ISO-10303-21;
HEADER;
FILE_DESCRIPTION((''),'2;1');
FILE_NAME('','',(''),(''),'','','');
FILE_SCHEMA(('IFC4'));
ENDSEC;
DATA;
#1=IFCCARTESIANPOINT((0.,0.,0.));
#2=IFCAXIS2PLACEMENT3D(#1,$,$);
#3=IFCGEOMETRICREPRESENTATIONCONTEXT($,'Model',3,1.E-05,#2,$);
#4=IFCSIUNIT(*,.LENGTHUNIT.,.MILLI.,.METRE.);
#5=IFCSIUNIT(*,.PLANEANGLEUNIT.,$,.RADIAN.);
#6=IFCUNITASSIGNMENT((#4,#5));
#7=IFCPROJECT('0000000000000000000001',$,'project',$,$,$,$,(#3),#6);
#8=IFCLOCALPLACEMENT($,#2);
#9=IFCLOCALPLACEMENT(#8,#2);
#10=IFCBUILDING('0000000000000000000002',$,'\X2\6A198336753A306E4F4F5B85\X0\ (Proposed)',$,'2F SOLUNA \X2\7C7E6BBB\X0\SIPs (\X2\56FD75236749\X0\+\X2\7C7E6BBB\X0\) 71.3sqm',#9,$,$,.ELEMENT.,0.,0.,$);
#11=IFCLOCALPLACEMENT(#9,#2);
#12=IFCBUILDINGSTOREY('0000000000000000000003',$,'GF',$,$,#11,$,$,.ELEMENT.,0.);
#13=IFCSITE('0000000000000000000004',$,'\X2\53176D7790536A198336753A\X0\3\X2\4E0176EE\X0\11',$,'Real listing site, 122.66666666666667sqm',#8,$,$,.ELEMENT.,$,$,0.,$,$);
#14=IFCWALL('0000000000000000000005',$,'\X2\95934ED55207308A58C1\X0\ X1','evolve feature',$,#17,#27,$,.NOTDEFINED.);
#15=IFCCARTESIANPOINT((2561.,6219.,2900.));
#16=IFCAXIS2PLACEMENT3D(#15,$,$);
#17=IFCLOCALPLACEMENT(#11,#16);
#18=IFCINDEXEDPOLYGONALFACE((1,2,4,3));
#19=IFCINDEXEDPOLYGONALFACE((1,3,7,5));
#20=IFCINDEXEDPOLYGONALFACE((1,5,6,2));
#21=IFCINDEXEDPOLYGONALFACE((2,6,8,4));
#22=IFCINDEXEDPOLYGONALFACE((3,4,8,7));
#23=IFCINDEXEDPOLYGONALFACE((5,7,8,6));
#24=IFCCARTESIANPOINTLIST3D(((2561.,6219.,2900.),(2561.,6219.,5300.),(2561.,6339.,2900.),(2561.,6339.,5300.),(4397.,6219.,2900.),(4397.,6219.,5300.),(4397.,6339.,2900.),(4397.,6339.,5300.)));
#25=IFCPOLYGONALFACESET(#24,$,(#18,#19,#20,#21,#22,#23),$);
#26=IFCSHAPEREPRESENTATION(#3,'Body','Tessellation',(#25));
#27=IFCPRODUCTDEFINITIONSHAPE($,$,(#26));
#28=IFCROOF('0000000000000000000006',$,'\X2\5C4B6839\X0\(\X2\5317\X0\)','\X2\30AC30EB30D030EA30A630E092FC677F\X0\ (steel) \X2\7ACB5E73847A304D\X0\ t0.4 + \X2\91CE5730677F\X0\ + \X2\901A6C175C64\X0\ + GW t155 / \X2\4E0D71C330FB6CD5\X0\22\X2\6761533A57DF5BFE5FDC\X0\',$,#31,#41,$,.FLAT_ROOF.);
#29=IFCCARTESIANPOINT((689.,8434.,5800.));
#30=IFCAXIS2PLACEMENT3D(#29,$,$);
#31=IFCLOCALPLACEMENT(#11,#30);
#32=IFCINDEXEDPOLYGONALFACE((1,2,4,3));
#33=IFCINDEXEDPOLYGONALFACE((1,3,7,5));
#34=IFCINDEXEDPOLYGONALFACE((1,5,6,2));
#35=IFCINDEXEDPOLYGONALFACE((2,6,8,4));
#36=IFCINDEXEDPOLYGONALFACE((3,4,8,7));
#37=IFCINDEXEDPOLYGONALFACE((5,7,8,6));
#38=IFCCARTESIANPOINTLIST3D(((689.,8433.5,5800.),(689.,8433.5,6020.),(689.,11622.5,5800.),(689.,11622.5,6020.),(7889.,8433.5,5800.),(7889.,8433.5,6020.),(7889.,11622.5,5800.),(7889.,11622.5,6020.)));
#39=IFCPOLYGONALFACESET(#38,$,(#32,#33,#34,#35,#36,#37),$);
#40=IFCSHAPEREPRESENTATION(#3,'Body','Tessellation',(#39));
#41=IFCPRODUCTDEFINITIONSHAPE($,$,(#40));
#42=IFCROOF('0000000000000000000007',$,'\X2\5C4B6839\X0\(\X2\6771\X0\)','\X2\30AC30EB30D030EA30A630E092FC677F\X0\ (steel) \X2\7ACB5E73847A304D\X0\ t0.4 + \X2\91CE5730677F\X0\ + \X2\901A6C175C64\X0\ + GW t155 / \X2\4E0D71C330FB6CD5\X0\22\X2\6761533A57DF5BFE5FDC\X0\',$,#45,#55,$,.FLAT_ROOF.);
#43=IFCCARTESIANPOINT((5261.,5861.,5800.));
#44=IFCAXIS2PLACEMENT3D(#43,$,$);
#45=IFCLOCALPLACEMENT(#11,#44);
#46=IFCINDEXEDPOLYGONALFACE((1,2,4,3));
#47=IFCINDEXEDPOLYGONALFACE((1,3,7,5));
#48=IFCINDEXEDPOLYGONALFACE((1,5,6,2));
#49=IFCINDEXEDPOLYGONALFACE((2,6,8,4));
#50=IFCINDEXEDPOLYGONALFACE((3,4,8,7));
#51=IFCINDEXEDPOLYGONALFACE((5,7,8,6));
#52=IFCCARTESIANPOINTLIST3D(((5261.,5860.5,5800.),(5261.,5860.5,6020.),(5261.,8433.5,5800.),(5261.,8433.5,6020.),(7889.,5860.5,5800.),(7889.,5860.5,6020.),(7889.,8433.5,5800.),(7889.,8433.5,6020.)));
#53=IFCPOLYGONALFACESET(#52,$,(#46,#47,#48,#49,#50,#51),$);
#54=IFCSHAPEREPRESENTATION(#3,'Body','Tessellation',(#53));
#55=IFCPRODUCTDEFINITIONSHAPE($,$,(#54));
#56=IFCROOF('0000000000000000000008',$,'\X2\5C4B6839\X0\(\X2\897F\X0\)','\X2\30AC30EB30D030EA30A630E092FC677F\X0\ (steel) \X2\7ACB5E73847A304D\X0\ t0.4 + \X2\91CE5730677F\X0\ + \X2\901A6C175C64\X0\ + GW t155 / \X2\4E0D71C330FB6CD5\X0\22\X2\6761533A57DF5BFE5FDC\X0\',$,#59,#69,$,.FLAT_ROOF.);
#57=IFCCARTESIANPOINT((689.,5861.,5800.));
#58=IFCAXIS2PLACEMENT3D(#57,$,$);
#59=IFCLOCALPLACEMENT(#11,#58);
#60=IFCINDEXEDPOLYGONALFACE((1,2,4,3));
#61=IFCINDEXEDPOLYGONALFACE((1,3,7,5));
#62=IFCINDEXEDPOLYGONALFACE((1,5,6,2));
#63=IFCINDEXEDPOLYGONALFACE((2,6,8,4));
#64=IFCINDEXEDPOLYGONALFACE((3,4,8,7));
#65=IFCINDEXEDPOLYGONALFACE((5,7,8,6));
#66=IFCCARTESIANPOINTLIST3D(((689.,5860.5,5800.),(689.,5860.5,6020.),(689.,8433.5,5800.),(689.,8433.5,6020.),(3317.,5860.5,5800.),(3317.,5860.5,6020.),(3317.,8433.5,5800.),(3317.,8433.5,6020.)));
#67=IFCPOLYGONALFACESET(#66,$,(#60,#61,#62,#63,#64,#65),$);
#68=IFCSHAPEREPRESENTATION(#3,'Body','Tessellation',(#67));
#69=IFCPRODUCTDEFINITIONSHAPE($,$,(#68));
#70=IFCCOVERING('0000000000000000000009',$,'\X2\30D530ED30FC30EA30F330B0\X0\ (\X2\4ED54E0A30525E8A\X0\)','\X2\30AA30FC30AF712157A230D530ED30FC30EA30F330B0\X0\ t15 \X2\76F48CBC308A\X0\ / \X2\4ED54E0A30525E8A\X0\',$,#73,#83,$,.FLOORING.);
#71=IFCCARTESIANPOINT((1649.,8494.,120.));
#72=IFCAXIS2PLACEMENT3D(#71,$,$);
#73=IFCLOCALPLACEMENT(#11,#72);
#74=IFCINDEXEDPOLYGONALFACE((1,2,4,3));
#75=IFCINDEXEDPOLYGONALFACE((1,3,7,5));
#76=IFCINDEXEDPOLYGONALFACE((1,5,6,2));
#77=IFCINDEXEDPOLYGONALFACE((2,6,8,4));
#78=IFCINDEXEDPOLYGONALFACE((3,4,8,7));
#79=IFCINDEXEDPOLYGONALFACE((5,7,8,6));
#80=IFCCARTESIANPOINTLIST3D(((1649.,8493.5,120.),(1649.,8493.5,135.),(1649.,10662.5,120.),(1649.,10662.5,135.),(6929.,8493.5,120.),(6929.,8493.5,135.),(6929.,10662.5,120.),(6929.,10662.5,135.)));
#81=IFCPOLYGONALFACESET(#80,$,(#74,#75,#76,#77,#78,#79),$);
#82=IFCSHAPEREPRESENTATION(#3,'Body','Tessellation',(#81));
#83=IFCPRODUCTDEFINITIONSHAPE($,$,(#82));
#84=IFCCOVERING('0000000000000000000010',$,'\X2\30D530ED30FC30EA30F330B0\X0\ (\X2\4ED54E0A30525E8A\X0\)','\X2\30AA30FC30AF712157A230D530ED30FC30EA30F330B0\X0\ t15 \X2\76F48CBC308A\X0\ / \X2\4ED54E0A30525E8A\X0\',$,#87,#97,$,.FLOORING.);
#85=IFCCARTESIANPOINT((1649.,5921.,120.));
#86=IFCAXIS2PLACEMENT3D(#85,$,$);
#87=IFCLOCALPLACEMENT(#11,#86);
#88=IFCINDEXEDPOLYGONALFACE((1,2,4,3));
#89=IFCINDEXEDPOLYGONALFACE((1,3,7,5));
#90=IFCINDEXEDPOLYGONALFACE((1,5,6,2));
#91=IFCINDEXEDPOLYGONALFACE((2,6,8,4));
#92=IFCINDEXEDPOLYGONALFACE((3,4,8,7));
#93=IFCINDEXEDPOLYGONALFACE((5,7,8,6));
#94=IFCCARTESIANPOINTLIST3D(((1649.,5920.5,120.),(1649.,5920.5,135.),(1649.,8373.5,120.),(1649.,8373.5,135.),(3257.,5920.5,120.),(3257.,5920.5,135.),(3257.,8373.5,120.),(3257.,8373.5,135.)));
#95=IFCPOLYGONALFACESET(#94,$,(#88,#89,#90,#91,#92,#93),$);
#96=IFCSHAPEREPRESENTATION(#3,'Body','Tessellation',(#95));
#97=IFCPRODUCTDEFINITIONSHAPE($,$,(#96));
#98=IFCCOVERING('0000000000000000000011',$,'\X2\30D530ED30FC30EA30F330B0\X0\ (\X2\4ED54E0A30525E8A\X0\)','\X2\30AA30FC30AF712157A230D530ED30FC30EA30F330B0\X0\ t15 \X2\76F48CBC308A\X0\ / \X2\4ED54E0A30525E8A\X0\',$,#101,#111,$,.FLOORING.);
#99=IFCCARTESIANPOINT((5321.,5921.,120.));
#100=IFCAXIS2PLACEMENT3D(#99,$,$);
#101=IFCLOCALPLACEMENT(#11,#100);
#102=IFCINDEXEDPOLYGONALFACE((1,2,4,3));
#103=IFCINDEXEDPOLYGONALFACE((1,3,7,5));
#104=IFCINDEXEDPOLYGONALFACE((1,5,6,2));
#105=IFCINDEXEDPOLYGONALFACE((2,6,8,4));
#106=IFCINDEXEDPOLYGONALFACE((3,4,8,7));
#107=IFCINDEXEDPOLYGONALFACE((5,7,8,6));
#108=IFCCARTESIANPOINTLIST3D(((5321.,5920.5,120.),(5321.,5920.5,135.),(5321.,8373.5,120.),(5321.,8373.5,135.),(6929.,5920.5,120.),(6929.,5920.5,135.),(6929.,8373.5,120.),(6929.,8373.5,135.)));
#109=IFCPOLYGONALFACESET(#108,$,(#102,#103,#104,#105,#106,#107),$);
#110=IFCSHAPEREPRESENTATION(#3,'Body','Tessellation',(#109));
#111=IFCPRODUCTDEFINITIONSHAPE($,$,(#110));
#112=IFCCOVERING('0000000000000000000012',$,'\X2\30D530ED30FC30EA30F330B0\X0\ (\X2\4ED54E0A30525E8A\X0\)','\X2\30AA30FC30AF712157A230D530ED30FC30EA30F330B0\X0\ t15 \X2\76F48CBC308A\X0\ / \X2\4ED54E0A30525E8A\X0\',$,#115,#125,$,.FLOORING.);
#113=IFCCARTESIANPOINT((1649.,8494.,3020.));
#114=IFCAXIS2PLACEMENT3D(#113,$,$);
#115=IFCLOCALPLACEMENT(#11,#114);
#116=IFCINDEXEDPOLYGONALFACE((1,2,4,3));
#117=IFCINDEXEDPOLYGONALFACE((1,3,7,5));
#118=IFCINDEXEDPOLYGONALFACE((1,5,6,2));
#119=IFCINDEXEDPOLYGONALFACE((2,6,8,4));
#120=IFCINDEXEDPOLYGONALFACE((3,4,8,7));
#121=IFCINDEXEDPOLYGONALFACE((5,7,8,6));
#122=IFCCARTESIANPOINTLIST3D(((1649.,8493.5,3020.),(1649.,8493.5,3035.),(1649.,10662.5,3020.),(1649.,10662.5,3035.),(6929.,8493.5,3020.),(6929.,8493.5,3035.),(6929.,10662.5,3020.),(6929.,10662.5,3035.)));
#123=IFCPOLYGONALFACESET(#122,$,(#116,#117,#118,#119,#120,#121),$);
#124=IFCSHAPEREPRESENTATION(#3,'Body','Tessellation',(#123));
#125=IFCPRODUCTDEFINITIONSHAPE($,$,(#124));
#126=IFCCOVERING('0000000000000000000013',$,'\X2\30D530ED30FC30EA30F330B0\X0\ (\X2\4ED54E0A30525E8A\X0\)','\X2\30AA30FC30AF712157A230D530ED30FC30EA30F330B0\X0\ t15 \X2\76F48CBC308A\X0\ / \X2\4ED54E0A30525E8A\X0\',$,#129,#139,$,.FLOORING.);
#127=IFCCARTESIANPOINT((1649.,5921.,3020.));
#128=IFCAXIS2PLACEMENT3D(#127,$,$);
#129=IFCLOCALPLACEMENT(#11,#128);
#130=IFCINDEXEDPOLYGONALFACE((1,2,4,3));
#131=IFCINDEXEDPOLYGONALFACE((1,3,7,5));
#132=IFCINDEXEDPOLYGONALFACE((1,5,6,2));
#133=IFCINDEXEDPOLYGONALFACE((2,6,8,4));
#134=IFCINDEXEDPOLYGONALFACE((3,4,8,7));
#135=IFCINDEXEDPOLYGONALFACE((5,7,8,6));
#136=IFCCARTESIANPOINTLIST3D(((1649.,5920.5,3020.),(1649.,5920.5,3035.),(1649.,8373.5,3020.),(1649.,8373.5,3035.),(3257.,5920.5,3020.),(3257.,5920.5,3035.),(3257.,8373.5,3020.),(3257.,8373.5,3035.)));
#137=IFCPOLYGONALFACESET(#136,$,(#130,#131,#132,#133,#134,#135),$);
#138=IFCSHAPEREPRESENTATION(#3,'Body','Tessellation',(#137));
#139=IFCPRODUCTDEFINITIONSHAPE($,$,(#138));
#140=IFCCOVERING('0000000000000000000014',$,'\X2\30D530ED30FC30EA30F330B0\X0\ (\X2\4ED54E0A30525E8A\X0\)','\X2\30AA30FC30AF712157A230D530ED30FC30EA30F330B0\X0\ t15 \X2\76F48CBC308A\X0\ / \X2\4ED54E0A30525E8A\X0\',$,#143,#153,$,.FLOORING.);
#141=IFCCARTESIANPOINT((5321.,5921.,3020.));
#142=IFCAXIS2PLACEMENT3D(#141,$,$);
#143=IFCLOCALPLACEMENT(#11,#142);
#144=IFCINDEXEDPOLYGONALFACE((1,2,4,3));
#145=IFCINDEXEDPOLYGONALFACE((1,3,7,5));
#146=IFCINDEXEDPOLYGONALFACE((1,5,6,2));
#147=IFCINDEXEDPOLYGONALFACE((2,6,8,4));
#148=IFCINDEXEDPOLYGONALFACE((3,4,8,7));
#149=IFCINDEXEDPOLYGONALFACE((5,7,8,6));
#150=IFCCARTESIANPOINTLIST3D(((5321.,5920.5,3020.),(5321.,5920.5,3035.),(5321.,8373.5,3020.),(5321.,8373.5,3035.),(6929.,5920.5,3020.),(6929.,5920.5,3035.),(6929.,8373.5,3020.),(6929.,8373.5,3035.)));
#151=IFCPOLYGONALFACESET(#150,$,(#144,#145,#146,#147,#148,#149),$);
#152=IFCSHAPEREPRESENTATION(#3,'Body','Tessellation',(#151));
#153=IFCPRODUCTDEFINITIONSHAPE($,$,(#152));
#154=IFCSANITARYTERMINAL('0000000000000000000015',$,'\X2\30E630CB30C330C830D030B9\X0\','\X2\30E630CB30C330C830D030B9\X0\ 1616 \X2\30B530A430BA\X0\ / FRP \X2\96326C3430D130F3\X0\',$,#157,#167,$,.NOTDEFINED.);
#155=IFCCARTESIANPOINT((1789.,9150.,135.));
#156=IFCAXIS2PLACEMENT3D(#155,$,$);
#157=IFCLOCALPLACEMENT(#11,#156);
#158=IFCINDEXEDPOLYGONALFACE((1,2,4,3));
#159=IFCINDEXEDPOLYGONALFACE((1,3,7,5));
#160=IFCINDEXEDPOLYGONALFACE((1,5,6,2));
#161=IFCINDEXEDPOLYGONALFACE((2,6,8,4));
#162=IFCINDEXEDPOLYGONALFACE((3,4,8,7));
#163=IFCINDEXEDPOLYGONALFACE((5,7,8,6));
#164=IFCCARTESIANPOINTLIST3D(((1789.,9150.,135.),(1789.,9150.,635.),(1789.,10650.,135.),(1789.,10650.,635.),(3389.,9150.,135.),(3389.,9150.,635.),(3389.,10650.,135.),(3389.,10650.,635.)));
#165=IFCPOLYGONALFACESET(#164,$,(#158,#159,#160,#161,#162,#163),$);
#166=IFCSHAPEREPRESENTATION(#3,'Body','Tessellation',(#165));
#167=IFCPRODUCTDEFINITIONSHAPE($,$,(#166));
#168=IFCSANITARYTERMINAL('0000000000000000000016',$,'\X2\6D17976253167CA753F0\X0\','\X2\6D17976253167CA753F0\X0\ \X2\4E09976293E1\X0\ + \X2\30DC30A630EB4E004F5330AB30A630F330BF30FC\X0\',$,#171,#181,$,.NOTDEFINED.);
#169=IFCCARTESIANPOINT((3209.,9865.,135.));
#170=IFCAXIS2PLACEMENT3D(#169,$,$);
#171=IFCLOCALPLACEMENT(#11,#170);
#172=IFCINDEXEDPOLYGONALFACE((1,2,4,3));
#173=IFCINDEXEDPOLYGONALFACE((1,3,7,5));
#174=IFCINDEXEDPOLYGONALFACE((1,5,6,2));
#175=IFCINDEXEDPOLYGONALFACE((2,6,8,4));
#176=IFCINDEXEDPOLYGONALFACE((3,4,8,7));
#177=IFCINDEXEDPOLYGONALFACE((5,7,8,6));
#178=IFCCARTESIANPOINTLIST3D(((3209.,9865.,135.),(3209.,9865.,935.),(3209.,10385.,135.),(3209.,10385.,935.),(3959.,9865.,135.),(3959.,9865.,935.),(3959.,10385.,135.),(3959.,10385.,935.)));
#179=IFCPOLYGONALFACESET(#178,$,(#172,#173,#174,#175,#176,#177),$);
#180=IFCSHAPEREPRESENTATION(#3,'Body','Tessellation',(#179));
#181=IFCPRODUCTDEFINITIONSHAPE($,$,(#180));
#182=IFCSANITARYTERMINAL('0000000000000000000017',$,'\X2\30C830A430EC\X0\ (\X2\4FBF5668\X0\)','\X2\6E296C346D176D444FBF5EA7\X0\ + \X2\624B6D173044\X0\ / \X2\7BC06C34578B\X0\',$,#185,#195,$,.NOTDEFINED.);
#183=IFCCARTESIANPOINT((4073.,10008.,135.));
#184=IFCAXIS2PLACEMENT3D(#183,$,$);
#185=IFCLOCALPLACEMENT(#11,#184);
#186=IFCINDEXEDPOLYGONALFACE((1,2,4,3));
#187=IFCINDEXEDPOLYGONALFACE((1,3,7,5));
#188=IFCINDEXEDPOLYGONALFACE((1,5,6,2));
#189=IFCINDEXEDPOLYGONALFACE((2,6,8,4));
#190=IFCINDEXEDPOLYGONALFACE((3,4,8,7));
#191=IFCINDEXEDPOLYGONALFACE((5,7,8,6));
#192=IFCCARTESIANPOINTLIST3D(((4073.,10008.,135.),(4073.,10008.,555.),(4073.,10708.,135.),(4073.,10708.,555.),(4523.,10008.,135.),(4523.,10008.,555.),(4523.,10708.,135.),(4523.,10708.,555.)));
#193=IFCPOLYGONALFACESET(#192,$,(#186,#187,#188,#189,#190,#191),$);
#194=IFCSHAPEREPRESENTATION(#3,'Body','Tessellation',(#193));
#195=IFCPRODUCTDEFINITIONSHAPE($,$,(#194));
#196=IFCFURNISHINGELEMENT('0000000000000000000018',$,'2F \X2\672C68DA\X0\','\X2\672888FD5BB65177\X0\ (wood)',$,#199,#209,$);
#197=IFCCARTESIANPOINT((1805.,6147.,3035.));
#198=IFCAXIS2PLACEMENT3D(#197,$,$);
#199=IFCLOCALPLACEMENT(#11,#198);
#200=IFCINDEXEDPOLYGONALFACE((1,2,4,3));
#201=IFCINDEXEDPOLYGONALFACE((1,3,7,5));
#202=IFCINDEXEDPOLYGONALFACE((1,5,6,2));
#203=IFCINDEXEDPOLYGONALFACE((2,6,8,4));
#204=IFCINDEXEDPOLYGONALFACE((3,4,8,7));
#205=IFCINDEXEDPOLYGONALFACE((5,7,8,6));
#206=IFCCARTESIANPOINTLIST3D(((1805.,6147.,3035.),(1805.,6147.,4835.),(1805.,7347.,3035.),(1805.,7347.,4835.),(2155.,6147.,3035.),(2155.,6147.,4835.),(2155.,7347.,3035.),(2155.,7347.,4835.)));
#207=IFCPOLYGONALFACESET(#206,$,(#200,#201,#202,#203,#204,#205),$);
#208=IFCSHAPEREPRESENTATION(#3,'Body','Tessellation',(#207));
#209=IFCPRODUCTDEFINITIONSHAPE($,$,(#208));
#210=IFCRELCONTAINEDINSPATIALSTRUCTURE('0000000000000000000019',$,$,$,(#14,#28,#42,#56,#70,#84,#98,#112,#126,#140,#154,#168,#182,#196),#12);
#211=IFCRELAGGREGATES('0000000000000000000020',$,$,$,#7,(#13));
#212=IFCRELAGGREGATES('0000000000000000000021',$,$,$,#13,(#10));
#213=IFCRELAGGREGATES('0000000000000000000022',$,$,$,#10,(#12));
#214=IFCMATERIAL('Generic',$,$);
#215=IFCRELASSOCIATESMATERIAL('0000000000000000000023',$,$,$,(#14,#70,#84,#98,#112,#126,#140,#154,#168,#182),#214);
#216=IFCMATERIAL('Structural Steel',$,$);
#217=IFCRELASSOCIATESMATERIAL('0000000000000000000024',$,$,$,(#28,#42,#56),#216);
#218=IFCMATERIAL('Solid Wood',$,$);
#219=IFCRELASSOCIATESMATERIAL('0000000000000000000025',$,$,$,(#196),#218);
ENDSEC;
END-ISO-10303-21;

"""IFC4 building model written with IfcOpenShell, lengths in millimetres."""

from ifc_helpers import new_model, si_unit, frame, frame_2d, origin, place, context, project, spatial, rectangle, extrude, material, element, save


model = new_model("IFC4")

# Units and contexts
model_context = context("Model", 3, precision=1e-05, world=origin())
ifc_project = project(units=[si_unit("LENGTHUNIT", "METRE", prefix="MILLI"), si_unit("PLANEANGLEUNIT", "RADIAN")], contexts=[model_context])

# Site, building, storey
site_placement = place(None, origin())
site = spatial("IfcSite", under=ifc_project, at=site_placement, Name="北海道標茶町3丁目11", ObjectType="Real listing site, 122.66666666666667sqm", CompositionType="ELEMENT", RefElevation=0.0)
building_placement = place(site_placement, origin())
building = spatial("IfcBuilding", under=site, at=building_placement, Name="標茶町の住宅 (Proposed)", ObjectType="2F SOLUNA 籾殻SIPs (国産杉+籾殻) 71.3sqm", CompositionType="ELEMENT", ElevationOfRefHeight=0.0, ElevationOfTerrain=0.0)
storey_placement = place(building_placement, origin())
storey = spatial("IfcBuildingStorey", under=building, at=storey_placement, Name="GF", CompositionType="ELEMENT", Elevation=0.0)

# Shared definitions
ifc_material_1 = material(Name="Solid Wood")

# Shared definitions
ifc_material_2 = material(Name="Generic")

# Wall
wall_1_placement = place(storey_placement, frame((2561.0, 6219.0, 2900.0)))
element("IfcWall", 1, at=wall_1_placement, inside=storey, material=ifc_material_2, Name="間仕切り壁 X1", Description="evolve feature", PredefinedType="NOTDEFINED", context=model_context, shape_type="SweptSolid", body=[
    extrude(rectangle(XDim=1836.0, YDim=120.0, at=frame_2d((918.0, 60.0))), frame((2561.0, 6219.0, 2900.0)), (0.0, 0.0, 1.0), 2400.0),
])

# Roofs
ifc_material_3 = material(Name="Structural Steel")
roof_1_placement = place(storey_placement, frame((689.0, 8434.0, 5800.0)))
element("IfcRoof", 2, at=roof_1_placement, inside=storey, material=ifc_material_3, Name="屋根(北)", Description="ガルバリウム鋼板 (steel) 立平葺き t0.4 + 野地板 + 通気層 + GW t155 / 不燃・法22条区域対応", PredefinedType="FLAT_ROOF", context=model_context, shape_type="SweptSolid", body=[
    extrude(rectangle(XDim=7200.0, YDim=3189.0, at=frame_2d((3600.0, 1594.0))), frame((689.0, 8434.0, 5800.0)), (0.0, 0.0, 1.0), 220.0),
])
roof_2_placement = place(storey_placement, frame((5261.0, 5861.0, 5800.0)))
element("IfcRoof", 3, at=roof_2_placement, inside=storey, material=ifc_material_3, Name="屋根(東)", Description="ガルバリウム鋼板 (steel) 立平葺き t0.4 + 野地板 + 通気層 + GW t155 / 不燃・法22条区域対応", PredefinedType="FLAT_ROOF", context=model_context, shape_type="SweptSolid", body=[
    extrude(rectangle(XDim=2628.0, YDim=2573.0, at=frame_2d((1314.0, 1286.0))), frame((5261.0, 5861.0, 5800.0)), (0.0, 0.0, 1.0), 220.0),
])
roof_3_placement = place(storey_placement, frame((689.0, 5861.0, 5800.0)))
element("IfcRoof", 4, at=roof_3_placement, inside=storey, material=ifc_material_3, Name="屋根(西)", Description="ガルバリウム鋼板 (steel) 立平葺き t0.4 + 野地板 + 通気層 + GW t155 / 不燃・法22条区域対応", PredefinedType="FLAT_ROOF", context=model_context, shape_type="SweptSolid", body=[
    extrude(rectangle(XDim=2628.0, YDim=2573.0, at=frame_2d((1314.0, 1286.0))), frame((689.0, 5861.0, 5800.0)), (0.0, 0.0, 1.0), 220.0),
])

# Coverings
covering_1_placement = place(storey_placement, frame((1649.0, 8494.0, 120.0)))
element("IfcCovering", 5, at=covering_1_placement, inside=storey, material=ifc_material_2, Name="フローリング (仕上げ床)", Description="オーク無垢フローリング t15 直貼り / 仕上げ床", PredefinedType="FLOORING", context=model_context, shape_type="SweptSolid", body=[
    extrude(rectangle(XDim=5280.0, YDim=2169.0, at=frame_2d((2640.0, 1084.0))), frame((1649.0, 8494.0, 120.0)), (0.0, 0.0, 1.0), 15.0),
])
covering_2_placement = place(storey_placement, frame((1649.0, 5921.0, 120.0)))
element("IfcCovering", 6, at=covering_2_placement, inside=storey, material=ifc_material_2, Name="フローリング (仕上げ床)", Description="オーク無垢フローリング t15 直貼り / 仕上げ床", PredefinedType="FLOORING", context=model_context, shape_type="SweptSolid", body=[
    extrude(rectangle(XDim=1608.0, YDim=2453.0, at=frame_2d((804.0, 1226.0))), frame((1649.0, 5921.0, 120.0)), (0.0, 0.0, 1.0), 15.0),
])
covering_3_placement = place(storey_placement, frame((5321.0, 5921.0, 120.0)))
element("IfcCovering", 7, at=covering_3_placement, inside=storey, material=ifc_material_2, Name="フローリング (仕上げ床)", Description="オーク無垢フローリング t15 直貼り / 仕上げ床", PredefinedType="FLOORING", context=model_context, shape_type="SweptSolid", body=[
    extrude(rectangle(XDim=1608.0, YDim=2453.0, at=frame_2d((804.0, 1226.0))), frame((5321.0, 5921.0, 120.0)), (0.0, 0.0, 1.0), 15.0),
])
covering_4_placement = place(storey_placement, frame((1649.0, 8494.0, 3020.0)))
element("IfcCovering", 8, at=covering_4_placement, inside=storey, material=ifc_material_2, Name="フローリング (仕上げ床)", Description="オーク無垢フローリング t15 直貼り / 仕上げ床", PredefinedType="FLOORING", context=model_context, shape_type="SweptSolid", body=[
    extrude(rectangle(XDim=5280.0, YDim=2169.0, at=frame_2d((2640.0, 1084.0))), frame((1649.0, 8494.0, 3020.0)), (0.0, 0.0, 1.0), 15.0),
])
covering_5_placement = place(storey_placement, frame((1649.0, 5921.0, 3020.0)))
element("IfcCovering", 9, at=covering_5_placement, inside=storey, material=ifc_material_2, Name="フローリング (仕上げ床)", Description="オーク無垢フローリング t15 直貼り / 仕上げ床", PredefinedType="FLOORING", context=model_context, shape_type="SweptSolid", body=[
    extrude(rectangle(XDim=1608.0, YDim=2453.0, at=frame_2d((804.0, 1226.0))), frame((1649.0, 5921.0, 3020.0)), (0.0, 0.0, 1.0), 15.0),
])
covering_6_placement = place(storey_placement, frame((5321.0, 5921.0, 3020.0)))
element("IfcCovering", 10, at=covering_6_placement, inside=storey, material=ifc_material_2, Name="フローリング (仕上げ床)", Description="オーク無垢フローリング t15 直貼り / 仕上げ床", PredefinedType="FLOORING", context=model_context, shape_type="SweptSolid", body=[
    extrude(rectangle(XDim=1608.0, YDim=2453.0, at=frame_2d((804.0, 1226.0))), frame((5321.0, 5921.0, 3020.0)), (0.0, 0.0, 1.0), 15.0),
])

# Sanitary terminals
sanitary_terminal_1_placement = place(storey_placement, frame((1789.0, 9150.0, 135.0)))
element("IfcSanitaryTerminal", 11, at=sanitary_terminal_1_placement, inside=storey, material=ifc_material_2, Name="ユニットバス", Description="ユニットバス 1616 サイズ / FRP 防水パン", PredefinedType="NOTDEFINED", context=model_context, shape_type="SweptSolid", body=[
    extrude(rectangle(XDim=1600.0, YDim=1500.0, at=frame_2d((800.0, 750.0))), frame((1789.0, 9150.0, 135.0)), (0.0, 0.0, 1.0), 500.0),
])
sanitary_terminal_2_placement = place(storey_placement, frame((3209.0, 9865.0, 135.0)))
element("IfcSanitaryTerminal", 12, at=sanitary_terminal_2_placement, inside=storey, material=ifc_material_2, Name="洗面化粧台", Description="洗面化粧台 三面鏡 + ボウル一体カウンター", PredefinedType="NOTDEFINED", context=model_context, shape_type="SweptSolid", body=[
    extrude(rectangle(XDim=750.0, YDim=520.0, at=frame_2d((375.0, 260.0))), frame((3209.0, 9865.0, 135.0)), (0.0, 0.0, 1.0), 800.0),
])
sanitary_terminal_3_placement = place(storey_placement, frame((4073.0, 10008.0, 135.0)))
element("IfcSanitaryTerminal", 13, at=sanitary_terminal_3_placement, inside=storey, material=ifc_material_2, Name="トイレ (便器)", Description="温水洗浄便座 + 手洗い / 節水型", PredefinedType="NOTDEFINED", context=model_context, shape_type="SweptSolid", body=[
    extrude(rectangle(XDim=450.0, YDim=700.0, at=frame_2d((225.0, 350.0))), frame((4073.0, 10008.0, 135.0)), (0.0, 0.0, 1.0), 420.0),
])

# Furnishing element
furnishing_placement = place(storey_placement, frame((1805.0, 6147.0, 3035.0)))
element("IfcFurnishingElement", 14, at=furnishing_placement, inside=storey, material=ifc_material_1, Name="2F 本棚", Description="木製家具 (wood)", context=model_context, shape_type="SweptSolid", body=[
    extrude(rectangle(XDim=350.0, YDim=1200.0, at=frame_2d((175.0, 600.0))), frame((1805.0, 6147.0, 3035.0)), (0.0, 0.0, 1.0), 1800.0),
])

save(model, "model.ifc")
